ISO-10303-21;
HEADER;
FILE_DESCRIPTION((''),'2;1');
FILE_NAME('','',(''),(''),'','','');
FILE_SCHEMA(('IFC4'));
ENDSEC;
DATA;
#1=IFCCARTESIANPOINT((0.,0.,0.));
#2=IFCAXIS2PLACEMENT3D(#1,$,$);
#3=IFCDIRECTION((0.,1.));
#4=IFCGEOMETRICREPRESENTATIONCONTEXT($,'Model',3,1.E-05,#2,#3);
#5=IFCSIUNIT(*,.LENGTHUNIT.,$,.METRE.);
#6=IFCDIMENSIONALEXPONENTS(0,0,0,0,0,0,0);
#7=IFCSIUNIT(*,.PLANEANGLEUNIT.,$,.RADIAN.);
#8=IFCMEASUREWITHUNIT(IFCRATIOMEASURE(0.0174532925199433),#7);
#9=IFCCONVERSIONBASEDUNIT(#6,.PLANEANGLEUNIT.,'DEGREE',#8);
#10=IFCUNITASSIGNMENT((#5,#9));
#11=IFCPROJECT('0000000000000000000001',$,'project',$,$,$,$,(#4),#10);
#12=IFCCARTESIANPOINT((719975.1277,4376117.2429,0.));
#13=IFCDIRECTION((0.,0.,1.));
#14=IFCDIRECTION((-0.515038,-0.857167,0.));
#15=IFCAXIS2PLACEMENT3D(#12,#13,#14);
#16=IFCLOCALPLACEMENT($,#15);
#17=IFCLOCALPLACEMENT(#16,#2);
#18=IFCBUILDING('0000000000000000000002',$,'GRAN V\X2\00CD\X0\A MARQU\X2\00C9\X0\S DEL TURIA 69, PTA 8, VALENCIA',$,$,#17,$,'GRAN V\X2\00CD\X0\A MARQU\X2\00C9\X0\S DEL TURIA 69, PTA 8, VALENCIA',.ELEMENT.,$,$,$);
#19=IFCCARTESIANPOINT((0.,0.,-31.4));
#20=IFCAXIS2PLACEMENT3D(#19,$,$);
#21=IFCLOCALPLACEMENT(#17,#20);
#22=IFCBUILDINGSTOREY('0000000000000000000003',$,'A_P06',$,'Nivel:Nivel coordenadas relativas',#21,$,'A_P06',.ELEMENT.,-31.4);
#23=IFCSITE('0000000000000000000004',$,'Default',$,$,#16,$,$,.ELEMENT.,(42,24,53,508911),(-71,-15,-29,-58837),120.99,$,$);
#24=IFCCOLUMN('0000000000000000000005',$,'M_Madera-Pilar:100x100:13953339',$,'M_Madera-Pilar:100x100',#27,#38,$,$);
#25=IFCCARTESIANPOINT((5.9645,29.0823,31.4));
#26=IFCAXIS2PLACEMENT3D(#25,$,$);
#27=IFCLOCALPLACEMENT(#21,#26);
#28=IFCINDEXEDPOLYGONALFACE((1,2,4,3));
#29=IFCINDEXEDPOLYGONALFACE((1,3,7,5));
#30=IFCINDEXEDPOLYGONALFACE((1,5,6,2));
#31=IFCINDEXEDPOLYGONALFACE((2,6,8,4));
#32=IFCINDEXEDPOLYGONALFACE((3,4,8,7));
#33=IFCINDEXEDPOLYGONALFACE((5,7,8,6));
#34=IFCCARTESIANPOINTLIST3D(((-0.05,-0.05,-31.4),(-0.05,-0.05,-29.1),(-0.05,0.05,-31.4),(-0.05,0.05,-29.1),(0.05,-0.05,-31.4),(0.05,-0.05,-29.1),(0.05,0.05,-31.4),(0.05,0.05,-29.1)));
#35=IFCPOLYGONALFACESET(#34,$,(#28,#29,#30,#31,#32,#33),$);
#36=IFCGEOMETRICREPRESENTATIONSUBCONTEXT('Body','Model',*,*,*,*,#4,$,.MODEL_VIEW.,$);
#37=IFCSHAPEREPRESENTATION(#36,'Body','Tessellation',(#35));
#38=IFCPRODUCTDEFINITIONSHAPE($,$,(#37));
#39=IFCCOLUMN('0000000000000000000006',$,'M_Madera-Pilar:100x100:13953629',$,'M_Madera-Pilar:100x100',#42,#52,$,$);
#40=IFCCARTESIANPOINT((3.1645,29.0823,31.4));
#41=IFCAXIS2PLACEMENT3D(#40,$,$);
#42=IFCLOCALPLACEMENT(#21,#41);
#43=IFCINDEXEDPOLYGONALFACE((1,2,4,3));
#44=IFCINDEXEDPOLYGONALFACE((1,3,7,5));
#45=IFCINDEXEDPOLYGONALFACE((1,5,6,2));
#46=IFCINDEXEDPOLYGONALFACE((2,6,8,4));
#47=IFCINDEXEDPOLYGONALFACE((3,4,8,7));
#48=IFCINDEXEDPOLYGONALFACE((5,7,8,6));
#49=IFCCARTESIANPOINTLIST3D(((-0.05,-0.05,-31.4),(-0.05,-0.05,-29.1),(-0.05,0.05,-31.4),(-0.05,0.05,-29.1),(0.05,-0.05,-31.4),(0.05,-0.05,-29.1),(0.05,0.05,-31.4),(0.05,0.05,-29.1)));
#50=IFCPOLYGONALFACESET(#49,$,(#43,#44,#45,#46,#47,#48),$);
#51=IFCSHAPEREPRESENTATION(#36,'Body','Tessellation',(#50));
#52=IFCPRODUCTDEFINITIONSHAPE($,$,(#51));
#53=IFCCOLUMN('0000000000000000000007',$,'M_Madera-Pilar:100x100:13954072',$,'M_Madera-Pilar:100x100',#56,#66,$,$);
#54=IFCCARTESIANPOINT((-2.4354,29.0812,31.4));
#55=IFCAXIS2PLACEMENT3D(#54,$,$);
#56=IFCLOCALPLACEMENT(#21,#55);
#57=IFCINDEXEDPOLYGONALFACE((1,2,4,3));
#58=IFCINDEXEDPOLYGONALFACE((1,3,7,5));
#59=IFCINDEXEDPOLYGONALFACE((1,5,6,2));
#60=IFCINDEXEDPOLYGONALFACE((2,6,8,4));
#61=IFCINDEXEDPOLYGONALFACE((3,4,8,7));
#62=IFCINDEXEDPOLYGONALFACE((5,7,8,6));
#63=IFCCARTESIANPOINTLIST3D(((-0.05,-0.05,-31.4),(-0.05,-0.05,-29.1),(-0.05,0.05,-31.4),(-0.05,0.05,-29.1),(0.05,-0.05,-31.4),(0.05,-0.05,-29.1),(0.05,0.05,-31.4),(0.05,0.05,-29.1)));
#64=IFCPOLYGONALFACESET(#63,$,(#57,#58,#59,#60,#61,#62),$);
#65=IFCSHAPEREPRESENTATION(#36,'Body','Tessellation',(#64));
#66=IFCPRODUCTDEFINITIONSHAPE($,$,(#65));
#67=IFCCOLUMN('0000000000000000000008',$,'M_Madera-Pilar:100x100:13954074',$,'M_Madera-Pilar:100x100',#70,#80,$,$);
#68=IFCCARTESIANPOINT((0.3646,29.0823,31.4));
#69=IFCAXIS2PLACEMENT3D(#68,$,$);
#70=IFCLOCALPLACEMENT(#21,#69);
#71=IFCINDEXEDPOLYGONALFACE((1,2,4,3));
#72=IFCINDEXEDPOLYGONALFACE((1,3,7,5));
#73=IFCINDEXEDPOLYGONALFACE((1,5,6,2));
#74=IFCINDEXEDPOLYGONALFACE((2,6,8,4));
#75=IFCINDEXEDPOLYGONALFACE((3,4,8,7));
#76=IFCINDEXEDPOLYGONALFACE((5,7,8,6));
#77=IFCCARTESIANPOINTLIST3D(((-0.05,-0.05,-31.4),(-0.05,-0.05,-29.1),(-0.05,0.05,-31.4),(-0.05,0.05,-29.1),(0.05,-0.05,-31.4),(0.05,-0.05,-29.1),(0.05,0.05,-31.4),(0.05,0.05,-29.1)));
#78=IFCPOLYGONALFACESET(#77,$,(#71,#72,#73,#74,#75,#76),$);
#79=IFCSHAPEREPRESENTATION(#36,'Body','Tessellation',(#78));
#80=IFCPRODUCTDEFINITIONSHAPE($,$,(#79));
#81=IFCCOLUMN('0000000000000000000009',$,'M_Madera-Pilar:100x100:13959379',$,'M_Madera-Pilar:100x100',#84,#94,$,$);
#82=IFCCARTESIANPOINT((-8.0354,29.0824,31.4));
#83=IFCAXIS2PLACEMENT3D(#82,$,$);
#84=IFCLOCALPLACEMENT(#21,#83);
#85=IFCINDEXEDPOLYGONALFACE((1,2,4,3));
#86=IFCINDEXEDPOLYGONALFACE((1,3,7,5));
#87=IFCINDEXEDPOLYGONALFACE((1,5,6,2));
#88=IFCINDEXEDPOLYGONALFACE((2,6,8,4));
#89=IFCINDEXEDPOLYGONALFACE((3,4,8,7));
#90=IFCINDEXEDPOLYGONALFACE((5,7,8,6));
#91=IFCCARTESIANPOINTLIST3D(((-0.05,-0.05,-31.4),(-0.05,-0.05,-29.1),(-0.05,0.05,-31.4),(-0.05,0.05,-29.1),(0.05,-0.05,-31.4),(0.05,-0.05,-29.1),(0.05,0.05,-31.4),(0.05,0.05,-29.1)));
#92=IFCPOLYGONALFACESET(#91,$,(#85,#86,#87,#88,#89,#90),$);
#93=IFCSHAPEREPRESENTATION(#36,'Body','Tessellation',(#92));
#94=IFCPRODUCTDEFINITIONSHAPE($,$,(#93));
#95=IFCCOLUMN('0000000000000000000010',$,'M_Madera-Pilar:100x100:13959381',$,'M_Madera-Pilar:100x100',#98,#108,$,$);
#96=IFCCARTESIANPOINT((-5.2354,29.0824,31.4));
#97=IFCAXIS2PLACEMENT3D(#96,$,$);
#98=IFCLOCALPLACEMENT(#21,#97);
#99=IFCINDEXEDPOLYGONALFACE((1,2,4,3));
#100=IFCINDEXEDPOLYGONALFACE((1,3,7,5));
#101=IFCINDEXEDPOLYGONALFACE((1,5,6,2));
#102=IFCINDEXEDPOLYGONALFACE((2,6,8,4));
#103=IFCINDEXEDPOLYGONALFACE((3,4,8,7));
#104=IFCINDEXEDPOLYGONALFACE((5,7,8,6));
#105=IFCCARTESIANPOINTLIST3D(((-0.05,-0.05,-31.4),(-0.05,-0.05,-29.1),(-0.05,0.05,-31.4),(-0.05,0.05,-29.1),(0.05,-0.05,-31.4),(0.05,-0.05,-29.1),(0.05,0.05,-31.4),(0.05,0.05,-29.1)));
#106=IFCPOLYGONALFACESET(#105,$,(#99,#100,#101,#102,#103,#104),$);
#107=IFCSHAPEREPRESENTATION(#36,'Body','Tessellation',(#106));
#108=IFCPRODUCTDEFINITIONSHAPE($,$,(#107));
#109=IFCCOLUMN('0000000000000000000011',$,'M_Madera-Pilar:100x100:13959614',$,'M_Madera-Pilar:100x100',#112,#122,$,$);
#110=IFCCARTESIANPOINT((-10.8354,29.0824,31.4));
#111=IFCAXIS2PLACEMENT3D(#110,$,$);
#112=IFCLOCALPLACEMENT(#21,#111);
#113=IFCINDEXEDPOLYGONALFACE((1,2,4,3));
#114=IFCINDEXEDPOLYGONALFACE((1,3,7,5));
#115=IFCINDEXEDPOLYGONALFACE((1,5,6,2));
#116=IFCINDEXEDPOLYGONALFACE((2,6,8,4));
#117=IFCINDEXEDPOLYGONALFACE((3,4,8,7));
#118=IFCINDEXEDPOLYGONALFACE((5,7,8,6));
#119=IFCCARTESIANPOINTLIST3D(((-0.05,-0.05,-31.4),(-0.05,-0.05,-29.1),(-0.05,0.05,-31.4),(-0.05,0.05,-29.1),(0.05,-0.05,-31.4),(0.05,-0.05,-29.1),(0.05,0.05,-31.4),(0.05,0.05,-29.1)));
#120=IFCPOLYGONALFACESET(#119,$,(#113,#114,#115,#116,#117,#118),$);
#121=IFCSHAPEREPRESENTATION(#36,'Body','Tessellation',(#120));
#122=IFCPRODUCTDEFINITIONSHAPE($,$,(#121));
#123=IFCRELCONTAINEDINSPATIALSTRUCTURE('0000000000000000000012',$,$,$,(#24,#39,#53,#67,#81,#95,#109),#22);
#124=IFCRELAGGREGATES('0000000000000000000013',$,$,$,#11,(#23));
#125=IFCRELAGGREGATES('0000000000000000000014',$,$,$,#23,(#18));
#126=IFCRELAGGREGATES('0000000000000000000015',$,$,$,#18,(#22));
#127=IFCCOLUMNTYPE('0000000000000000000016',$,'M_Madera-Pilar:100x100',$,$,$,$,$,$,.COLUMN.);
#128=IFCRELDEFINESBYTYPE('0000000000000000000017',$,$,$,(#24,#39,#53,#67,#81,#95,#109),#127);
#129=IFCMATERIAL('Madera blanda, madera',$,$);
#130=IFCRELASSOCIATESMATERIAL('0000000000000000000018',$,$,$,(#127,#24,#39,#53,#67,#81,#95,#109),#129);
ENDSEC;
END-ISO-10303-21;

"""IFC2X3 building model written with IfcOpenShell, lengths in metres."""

from ifc_helpers import new_model, entity, si_unit, converted_unit, direction, frame, origin, origin_2d_with_axis, place, context, subcontext, project, spatial, rectangle, extrude, source, transform, mapped, material, type_object, type_shapes, element, save


model = new_model("IFC2X3")

# Units and contexts
model_context = context("Model", 3, precision=1e-05, world=origin(), true_north=direction((0.0, 1.0)))
body_context = subcontext(model_context, "Body", "Model", "MODEL_VIEW")
ifc_project = project(units=[si_unit("LENGTHUNIT", "METRE"), converted_unit("PLANEANGLEUNIT", "DEGREE", entity("IfcRatioMeasure", 0.0174532925199433), si_unit("PLANEANGLEUNIT", "RADIAN"), dimensions=[0, 0, 0, 0, 0, 0, 0])], contexts=[model_context])

# Site, building, storey
site_placement = place(None, frame((719975.1277, 4376117.2429, 0.0), z_axis=(0.0, 0.0, 1.0), x_axis=(-0.515038, -0.857167, 0.0)))
site = spatial("IfcSite", under=ifc_project, at=site_placement, Name="Default", CompositionType="ELEMENT", RefLatitude=(42, 24, 53, 508911), RefLongitude=(-71, -15, -29, -58837), RefElevation=120.99)
building_placement = place(site_placement, origin())
building = spatial("IfcBuilding", under=site, at=building_placement, Name="GRAN VÍA MARQUÉS DEL TURIA 69, PTA 8, VALENCIA", LongName="GRAN VÍA MARQUÉS DEL TURIA 69, PTA 8, VALENCIA", CompositionType="ELEMENT")
storey_placement = place(building_placement, frame((0.0, 0.0, -31.4)))
storey = spatial("IfcBuildingStorey", under=building, at=storey_placement, Name="A_P06", ObjectType="Nivel:Nivel coordenadas relativas", LongName="A_P06", CompositionType="ELEMENT", Elevation=-31.4)

# Columns
ifc_material_1 = material(Name="Madera blanda, madera")
column_type = type_object("IfcColumnType", Name="M_Madera-Pilar:100x100", PredefinedType="COLUMN", material=ifc_material_1)
shared_shape_1 = source(origin(), body_context, "Body", "SweptSolid", [
    extrude(rectangle(XDim=0.1, YDim=0.1, at=origin_2d_with_axis()), frame((0.0, 0.0, -31.4), z_axis=(0.0, 0.0, 1.0), x_axis=(0.0, -1.0, 0.0)), (0.0, 0.0, 1.0), 2.3),
])
type_shapes(column_type, [shared_shape_1])
for number, where, name in (
    (1, (5.9645, 29.0823, 31.4), "M_Madera-Pilar:100x100:13953339"),
    (2, (3.1645, 29.0823, 31.4), "M_Madera-Pilar:100x100:13953629"),
    (3, (-2.4354, 29.0812, 31.4), "M_Madera-Pilar:100x100:13954072"),
    (4, (0.3646, 29.0823, 31.4), "M_Madera-Pilar:100x100:13954074"),
    (5, (-8.0354, 29.0824, 31.4), "M_Madera-Pilar:100x100:13959379"),
    (6, (-5.2354, 29.0824, 31.4), "M_Madera-Pilar:100x100:13959381"),
    (7, (-10.8354, 29.0824, 31.4), "M_Madera-Pilar:100x100:13959614"),
):
    element("IfcColumn", number, at=place(storey_placement, frame(where)), inside=storey, type_object=column_type, material=ifc_material_1, Name=name, ObjectType="M_Madera-Pilar:100x100", context=body_context, shape_type="MappedRepresentation", body=[
        mapped(shared_shape_1, transform((0.0, 0.0, 0.0), scale=1.0)),
    ])

save(model, "model.ifc")
